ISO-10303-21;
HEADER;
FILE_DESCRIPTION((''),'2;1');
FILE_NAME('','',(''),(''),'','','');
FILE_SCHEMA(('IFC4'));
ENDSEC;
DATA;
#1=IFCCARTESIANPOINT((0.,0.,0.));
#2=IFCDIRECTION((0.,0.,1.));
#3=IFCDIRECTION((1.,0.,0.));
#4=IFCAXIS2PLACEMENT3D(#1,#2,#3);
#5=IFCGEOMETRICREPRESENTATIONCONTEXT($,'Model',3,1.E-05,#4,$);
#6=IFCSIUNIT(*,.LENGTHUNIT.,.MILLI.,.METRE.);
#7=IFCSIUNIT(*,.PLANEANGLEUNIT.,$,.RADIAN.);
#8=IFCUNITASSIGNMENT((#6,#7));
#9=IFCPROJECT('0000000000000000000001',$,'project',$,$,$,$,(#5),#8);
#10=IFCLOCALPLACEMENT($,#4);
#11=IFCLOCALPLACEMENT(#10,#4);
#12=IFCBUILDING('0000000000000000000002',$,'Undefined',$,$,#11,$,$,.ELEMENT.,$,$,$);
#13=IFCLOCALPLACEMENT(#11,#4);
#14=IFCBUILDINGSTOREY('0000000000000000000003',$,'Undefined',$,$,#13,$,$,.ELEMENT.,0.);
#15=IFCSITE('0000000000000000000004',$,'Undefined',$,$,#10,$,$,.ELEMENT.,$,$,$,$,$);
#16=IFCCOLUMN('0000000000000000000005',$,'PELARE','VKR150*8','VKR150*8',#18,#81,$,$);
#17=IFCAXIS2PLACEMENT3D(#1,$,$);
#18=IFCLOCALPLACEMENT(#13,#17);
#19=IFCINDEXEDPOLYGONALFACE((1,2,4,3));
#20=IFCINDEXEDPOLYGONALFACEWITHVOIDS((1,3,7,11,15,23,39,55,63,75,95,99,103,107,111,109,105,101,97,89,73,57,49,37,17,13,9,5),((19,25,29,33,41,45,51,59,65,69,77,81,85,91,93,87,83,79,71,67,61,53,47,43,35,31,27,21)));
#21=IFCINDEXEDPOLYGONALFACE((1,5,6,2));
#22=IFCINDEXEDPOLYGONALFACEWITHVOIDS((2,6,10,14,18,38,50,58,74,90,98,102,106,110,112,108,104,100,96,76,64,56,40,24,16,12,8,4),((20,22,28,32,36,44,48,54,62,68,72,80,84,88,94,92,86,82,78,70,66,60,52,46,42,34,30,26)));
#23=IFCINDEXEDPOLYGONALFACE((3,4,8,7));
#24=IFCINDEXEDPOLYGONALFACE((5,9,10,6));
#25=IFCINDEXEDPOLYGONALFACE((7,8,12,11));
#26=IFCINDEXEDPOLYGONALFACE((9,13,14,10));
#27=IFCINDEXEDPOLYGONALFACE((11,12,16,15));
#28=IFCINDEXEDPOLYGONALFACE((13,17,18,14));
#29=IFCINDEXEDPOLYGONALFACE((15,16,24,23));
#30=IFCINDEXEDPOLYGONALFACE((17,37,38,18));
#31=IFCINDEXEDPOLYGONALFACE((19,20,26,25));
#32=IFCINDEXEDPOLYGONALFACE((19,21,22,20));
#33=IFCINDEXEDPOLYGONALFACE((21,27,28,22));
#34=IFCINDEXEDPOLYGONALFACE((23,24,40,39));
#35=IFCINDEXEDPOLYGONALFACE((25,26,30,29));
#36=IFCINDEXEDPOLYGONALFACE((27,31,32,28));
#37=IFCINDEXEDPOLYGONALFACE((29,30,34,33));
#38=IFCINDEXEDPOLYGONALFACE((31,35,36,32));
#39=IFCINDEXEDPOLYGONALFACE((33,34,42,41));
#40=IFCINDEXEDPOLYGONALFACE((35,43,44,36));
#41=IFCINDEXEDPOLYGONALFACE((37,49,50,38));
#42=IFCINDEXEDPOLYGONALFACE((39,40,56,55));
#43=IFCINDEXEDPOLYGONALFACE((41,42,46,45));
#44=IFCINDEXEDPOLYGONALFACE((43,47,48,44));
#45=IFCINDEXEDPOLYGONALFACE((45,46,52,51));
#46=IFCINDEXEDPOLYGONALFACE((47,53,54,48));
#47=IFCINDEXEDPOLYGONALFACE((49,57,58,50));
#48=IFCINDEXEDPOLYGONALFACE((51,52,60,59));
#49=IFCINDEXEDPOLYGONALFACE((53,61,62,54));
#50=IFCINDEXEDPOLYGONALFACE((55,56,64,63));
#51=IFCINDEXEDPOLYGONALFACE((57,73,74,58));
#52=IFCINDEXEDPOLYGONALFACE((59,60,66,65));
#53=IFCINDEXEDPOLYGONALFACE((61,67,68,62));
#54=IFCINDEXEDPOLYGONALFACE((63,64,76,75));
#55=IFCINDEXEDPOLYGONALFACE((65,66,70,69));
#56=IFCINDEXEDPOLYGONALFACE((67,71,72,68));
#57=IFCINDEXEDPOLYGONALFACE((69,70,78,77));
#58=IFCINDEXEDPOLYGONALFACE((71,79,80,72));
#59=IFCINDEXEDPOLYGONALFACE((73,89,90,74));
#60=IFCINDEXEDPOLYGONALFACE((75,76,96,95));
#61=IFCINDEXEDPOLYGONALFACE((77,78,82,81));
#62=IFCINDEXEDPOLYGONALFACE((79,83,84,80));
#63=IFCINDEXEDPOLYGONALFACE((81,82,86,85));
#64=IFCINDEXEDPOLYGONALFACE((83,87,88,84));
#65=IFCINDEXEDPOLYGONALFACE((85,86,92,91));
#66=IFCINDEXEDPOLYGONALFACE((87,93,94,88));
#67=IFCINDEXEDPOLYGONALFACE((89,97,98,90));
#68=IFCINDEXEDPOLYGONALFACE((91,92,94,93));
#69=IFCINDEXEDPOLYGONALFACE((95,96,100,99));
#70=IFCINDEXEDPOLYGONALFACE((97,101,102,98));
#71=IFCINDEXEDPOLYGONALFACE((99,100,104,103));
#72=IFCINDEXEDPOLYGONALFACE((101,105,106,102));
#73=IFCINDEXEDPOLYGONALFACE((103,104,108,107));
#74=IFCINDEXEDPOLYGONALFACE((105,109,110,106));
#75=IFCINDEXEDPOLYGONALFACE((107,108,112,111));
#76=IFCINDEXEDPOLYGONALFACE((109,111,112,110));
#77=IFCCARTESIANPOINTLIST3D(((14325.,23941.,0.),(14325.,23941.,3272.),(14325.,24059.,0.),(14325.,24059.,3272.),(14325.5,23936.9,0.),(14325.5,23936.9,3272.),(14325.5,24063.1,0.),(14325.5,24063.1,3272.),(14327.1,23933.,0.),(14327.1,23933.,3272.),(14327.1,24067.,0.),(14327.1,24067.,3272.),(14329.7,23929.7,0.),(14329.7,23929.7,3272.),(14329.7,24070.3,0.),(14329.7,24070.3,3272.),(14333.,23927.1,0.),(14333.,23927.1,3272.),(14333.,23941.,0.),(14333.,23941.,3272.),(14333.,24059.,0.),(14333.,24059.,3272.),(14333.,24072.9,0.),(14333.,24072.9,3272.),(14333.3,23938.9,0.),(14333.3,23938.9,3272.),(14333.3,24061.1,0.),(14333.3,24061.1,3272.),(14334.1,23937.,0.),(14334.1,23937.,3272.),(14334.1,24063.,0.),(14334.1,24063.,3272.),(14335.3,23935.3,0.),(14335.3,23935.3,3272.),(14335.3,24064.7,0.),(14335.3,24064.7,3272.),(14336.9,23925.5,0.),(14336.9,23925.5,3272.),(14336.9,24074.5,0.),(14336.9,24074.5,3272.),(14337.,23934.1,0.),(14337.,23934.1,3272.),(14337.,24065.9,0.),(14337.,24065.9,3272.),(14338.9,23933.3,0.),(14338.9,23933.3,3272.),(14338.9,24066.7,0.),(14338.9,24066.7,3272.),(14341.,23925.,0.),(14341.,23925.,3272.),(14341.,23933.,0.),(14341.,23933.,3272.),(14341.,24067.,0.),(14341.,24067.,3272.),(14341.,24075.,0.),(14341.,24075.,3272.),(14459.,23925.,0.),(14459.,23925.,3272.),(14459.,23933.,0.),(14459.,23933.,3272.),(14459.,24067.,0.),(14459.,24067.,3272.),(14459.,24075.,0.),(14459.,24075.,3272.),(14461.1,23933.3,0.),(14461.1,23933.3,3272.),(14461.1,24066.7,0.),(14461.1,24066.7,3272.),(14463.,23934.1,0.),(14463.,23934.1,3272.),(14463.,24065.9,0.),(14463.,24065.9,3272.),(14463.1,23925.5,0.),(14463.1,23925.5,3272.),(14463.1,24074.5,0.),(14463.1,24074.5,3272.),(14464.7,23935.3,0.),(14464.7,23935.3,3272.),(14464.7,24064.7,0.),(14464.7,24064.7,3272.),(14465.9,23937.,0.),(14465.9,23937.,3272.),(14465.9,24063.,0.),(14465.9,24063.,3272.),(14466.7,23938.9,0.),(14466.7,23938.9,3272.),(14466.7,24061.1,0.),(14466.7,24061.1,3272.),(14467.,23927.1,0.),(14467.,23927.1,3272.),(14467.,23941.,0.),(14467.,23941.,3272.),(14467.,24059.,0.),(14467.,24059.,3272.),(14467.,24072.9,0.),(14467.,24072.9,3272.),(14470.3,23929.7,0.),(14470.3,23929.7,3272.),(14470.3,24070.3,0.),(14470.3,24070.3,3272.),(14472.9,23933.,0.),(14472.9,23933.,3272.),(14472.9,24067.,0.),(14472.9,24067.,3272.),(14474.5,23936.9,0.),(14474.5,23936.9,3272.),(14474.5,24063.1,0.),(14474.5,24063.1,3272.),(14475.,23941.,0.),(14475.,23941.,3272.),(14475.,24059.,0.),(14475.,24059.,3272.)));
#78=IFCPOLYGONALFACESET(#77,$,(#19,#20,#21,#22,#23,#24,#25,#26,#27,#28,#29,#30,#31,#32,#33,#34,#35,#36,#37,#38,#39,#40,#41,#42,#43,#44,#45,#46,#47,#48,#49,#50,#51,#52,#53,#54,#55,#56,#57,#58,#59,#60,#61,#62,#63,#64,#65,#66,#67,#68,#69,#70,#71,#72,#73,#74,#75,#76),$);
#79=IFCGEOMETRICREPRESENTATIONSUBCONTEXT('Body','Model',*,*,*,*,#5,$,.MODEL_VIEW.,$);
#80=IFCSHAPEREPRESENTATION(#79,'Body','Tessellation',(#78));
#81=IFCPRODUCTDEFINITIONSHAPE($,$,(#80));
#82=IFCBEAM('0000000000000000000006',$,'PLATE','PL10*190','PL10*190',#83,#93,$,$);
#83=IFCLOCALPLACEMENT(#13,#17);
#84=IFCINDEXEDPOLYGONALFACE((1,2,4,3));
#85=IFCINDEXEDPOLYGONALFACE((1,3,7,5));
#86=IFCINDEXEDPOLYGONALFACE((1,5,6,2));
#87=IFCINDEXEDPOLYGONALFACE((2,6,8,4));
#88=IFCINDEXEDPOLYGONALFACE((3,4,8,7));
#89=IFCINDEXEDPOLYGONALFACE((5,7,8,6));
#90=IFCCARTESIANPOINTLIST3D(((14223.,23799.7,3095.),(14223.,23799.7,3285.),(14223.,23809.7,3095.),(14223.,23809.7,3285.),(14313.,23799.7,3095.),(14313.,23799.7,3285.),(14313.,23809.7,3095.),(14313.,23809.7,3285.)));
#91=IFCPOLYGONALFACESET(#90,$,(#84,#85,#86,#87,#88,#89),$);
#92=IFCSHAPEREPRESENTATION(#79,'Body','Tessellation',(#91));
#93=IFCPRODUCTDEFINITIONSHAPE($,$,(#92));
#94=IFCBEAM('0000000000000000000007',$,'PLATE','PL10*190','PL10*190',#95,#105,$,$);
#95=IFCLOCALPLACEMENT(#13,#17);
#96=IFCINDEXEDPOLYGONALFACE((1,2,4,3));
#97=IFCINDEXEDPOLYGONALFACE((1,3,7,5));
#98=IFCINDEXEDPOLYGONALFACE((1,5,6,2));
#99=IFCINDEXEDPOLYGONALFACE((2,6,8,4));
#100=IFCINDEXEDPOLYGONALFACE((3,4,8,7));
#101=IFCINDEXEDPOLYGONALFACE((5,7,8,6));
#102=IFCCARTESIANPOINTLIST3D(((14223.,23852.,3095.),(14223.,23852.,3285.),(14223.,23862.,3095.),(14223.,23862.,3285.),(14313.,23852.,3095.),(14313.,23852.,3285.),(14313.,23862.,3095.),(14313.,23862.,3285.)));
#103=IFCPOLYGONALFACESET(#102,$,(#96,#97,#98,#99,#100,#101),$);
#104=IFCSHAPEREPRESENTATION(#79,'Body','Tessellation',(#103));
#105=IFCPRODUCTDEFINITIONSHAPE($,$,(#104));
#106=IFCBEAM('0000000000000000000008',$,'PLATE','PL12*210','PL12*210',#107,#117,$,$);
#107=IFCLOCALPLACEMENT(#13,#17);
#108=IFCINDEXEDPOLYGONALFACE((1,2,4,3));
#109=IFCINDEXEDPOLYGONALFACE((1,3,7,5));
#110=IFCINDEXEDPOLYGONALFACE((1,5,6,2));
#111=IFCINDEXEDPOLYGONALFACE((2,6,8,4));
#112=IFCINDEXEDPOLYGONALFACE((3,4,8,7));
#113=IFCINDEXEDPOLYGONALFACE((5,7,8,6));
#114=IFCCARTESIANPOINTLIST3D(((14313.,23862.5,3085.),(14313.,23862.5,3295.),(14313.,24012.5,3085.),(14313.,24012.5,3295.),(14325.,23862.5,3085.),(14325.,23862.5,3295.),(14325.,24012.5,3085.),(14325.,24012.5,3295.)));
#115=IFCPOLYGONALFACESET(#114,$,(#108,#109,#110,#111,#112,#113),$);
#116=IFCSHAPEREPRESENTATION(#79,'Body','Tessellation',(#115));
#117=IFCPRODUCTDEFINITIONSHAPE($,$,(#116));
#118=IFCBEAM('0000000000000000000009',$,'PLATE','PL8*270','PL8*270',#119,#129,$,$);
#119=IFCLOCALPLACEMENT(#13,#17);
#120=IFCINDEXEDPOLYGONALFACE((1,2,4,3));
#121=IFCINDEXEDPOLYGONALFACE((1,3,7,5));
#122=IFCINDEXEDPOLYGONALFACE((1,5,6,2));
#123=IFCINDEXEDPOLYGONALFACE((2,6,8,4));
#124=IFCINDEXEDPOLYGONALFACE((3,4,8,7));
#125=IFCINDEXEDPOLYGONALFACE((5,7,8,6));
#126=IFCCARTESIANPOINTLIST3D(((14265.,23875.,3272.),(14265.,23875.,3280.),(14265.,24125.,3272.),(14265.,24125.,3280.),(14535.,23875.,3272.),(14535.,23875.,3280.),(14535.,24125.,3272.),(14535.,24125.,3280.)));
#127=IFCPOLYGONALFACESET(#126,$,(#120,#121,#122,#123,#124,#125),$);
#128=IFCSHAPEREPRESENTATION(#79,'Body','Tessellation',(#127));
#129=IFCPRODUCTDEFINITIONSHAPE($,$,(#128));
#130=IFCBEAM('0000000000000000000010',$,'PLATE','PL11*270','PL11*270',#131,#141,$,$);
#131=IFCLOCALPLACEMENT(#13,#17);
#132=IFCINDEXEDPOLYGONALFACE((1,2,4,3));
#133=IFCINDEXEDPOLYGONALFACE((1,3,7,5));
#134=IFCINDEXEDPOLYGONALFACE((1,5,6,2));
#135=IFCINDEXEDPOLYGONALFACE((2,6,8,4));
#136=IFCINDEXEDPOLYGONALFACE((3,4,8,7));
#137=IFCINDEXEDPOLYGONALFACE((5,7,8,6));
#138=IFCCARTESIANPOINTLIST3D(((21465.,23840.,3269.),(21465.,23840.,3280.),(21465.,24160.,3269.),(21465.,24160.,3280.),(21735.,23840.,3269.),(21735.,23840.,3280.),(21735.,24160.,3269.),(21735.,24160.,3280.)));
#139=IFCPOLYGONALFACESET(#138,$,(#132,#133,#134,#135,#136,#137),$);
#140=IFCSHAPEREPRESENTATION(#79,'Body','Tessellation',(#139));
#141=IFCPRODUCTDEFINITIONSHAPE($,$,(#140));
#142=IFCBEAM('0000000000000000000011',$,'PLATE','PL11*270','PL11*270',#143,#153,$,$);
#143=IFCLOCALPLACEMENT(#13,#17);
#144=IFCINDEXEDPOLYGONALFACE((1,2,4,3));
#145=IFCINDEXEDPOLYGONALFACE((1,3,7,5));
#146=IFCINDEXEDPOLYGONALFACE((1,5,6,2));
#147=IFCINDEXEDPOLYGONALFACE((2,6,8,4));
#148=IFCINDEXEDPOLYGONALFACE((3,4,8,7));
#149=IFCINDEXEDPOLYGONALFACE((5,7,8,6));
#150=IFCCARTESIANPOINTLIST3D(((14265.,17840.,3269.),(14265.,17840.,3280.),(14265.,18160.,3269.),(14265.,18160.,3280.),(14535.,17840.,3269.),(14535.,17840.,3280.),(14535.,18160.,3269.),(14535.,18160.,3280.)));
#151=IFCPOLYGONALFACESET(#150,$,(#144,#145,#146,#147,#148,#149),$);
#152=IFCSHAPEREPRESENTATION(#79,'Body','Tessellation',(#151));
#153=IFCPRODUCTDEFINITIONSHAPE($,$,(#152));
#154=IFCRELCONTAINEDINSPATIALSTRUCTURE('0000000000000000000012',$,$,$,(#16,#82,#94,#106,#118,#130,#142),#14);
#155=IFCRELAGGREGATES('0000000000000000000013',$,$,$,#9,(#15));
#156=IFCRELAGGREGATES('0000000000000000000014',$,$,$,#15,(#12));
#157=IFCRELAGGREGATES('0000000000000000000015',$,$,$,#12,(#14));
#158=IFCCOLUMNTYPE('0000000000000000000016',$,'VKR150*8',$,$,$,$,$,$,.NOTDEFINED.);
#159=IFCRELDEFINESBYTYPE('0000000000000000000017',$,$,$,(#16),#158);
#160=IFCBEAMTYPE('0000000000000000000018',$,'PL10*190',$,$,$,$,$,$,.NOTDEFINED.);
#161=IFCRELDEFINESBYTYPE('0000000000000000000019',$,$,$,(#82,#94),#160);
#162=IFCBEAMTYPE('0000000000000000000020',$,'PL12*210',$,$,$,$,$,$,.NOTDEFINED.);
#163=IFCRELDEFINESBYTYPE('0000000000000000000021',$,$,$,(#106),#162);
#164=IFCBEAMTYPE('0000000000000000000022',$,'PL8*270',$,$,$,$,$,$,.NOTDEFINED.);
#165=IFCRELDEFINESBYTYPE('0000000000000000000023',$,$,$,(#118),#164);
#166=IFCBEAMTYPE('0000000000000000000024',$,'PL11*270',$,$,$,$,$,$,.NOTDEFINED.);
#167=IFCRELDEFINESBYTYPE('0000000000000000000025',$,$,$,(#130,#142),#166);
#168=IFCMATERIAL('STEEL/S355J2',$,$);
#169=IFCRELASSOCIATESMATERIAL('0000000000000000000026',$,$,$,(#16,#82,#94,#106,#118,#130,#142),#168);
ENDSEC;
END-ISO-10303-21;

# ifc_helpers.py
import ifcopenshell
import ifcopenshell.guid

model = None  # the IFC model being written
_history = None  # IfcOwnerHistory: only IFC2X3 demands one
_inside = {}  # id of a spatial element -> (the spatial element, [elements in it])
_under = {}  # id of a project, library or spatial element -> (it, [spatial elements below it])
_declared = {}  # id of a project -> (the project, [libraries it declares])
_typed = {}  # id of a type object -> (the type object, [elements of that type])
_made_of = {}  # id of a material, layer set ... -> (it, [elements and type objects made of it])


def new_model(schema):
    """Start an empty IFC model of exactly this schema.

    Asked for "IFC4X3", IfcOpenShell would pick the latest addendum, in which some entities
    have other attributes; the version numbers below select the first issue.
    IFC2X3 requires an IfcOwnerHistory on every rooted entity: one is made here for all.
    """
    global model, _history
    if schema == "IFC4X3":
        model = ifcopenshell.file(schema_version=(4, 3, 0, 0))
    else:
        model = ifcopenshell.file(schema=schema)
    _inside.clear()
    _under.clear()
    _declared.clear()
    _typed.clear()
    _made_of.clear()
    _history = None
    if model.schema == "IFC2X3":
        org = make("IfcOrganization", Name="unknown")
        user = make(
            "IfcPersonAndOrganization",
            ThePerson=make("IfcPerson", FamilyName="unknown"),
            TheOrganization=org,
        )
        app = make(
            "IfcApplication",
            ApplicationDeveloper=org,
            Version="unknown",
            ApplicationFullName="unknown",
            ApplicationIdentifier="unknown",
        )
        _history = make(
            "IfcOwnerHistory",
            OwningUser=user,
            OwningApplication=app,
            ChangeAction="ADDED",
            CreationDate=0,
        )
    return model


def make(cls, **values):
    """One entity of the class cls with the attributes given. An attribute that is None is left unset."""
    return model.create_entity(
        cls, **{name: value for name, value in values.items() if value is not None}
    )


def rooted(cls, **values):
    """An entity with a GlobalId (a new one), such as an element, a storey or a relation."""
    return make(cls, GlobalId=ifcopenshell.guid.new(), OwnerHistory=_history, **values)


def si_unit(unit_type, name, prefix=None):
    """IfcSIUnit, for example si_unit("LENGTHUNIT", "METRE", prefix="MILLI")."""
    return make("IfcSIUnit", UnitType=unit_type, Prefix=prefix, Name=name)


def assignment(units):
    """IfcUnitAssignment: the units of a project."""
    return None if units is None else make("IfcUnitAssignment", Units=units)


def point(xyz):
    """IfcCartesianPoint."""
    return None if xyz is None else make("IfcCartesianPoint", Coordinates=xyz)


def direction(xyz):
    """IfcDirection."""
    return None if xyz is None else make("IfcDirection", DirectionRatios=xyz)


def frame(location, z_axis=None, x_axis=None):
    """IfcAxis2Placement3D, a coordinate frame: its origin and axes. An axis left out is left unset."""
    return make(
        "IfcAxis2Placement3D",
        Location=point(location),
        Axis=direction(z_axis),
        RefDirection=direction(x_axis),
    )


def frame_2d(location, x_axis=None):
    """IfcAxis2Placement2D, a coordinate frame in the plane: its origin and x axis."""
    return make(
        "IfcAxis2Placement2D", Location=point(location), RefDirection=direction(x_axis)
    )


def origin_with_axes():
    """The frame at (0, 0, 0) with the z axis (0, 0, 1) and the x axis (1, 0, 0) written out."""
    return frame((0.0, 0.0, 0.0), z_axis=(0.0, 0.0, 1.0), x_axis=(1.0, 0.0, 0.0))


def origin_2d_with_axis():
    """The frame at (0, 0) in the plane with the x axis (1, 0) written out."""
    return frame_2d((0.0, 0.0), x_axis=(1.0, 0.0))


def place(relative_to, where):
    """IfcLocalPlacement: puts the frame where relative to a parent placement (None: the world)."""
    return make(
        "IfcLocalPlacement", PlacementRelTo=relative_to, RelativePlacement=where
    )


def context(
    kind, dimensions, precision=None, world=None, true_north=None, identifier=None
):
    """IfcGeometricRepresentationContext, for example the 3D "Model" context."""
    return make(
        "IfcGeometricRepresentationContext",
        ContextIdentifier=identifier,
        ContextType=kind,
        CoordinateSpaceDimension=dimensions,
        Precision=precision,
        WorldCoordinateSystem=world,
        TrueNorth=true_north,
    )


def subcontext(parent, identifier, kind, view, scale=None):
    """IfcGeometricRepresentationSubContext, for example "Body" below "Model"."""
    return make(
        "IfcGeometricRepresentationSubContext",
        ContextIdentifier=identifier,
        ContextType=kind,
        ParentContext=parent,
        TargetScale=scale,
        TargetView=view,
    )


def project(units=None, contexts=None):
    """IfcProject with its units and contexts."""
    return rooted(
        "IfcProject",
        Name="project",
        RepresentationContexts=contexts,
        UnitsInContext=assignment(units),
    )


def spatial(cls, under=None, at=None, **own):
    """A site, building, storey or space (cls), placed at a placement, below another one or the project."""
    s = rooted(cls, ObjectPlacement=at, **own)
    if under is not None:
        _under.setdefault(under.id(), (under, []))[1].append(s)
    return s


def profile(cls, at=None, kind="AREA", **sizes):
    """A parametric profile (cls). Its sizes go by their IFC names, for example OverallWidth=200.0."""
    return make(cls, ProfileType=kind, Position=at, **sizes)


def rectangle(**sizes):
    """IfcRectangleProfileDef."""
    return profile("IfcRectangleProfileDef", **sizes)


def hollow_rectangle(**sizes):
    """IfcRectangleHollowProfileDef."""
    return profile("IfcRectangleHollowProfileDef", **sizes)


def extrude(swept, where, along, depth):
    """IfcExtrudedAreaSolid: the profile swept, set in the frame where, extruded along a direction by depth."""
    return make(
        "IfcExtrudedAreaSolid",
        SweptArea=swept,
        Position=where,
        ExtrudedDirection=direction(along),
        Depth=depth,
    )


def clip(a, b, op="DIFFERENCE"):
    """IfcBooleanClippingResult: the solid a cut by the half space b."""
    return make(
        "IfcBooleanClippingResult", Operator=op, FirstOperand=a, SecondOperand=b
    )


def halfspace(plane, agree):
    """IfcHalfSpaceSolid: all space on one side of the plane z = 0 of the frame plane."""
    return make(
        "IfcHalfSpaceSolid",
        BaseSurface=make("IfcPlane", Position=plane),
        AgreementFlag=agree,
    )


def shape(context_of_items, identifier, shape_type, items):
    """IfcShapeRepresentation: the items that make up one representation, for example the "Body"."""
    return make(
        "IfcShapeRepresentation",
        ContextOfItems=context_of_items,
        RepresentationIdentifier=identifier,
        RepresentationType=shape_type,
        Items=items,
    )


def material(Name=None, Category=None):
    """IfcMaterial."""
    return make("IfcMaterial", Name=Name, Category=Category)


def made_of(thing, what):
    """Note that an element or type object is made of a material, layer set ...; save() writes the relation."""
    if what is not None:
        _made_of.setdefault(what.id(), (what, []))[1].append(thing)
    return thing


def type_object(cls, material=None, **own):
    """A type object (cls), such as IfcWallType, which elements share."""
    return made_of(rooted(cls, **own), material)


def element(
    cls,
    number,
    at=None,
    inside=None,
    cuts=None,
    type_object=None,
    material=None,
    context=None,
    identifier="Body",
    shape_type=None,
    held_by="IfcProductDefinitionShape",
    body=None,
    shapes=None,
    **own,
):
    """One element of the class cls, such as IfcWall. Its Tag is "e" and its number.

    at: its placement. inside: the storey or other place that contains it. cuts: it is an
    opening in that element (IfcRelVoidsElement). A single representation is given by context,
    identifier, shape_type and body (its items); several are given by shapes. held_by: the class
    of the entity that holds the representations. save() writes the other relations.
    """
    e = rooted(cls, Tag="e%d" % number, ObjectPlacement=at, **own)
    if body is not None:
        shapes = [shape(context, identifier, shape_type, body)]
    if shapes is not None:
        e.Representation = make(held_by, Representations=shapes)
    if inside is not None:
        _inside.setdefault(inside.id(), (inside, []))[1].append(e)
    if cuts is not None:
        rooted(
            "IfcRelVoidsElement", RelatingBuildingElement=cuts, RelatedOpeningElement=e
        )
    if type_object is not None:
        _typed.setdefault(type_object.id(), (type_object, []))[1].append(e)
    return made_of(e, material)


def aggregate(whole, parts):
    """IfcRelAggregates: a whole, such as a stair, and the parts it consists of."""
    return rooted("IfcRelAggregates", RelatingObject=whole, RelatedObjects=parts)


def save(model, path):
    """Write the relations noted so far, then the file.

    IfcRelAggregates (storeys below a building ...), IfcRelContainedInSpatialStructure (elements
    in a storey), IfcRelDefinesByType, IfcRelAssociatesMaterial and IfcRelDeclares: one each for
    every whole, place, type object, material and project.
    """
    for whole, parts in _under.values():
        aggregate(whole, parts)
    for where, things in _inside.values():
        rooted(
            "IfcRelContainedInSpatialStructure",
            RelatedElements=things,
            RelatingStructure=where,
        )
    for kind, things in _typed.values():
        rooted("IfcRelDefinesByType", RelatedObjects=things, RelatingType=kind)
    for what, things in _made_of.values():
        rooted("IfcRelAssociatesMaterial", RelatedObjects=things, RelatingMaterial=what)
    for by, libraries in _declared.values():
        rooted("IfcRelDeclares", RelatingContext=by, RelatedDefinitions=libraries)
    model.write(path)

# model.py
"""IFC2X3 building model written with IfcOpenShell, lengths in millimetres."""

from ifc_helpers import new_model, si_unit, frame, origin_with_axes, origin_2d_with_axis, place, context, subcontext, project, spatial, rectangle, hollow_rectangle, extrude, clip, halfspace, material, type_object, element, save


model = new_model("IFC2X3")

# Units and contexts
model_context = context("Model", 3, precision=1e-05, world=origin_with_axes())
body_context = subcontext(model_context, "Body", "Model", "MODEL_VIEW")
ifc_project = project(units=[si_unit("LENGTHUNIT", "METRE", prefix="MILLI"), si_unit("PLANEANGLEUNIT", "RADIAN")], contexts=[model_context])

# Site, building, storey
site_placement = place(None, origin_with_axes())
site = spatial("IfcSite", under=ifc_project, at=site_placement, Name="Undefined", CompositionType="ELEMENT")
building_placement = place(site_placement, origin_with_axes())
building = spatial("IfcBuilding", under=site, at=building_placement, Name="Undefined", CompositionType="ELEMENT")
storey_placement = place(building_placement, origin_with_axes())
storey = spatial("IfcBuildingStorey", under=building, at=storey_placement, Name="Undefined", CompositionType="ELEMENT", Elevation=0.0)

# Column
ifc_material_1 = material(Name="STEEL/S355J2")
column_type_1 = type_object("IfcColumnType", Name="VKR150*8", PredefinedType="NOTDEFINED")
column_1_placement = place(storey_placement, frame((14400.0, 24000.0, 0.0), z_axis=(0.0, 0.0, 1.0), x_axis=(0.0, 1.0, 0.0)))
element("IfcColumn", 1, at=column_1_placement, inside=storey, type_object=column_type_1, material=ifc_material_1, Name="PELARE", Description="VKR150*8", ObjectType="VKR150*8", context=body_context, shape_type="Clipping", body=[
    clip(extrude(hollow_rectangle(XDim=150.0, YDim=150.0, WallThickness=8.0, InnerFilletRadius=8.0, OuterFilletRadius=16.0, at=origin_2d_with_axis()), frame((0.0, 0.0, 3272.0), z_axis=(0.0, 0.0, -1.0), x_axis=(0.0, 1.0, 0.0)), (0.0, 0.0, 1.0), 3272.0), halfspace(frame((125.0, 0.0, 3272.0), z_axis=(0.0, 0.0, 1.0), x_axis=(0.0, -1.0, 0.0)), False)),
])

# Beams
beam_type_1 = type_object("IfcBeamType", Name="PL10*190", PredefinedType="NOTDEFINED")
for number, where, z_axis, x_axis, name in (
    (2, (14313.0, 23804.7, 3190.0), (0.0, 0.0, 1.0), (-1.0, 0.0, 0.0), "PLATE"),
    (3, (14313.0, 23857.0, 3190.0), (0.0, 0.0, 1.0), (-1.0, 0.0, 0.0), "PLATE"),
):
    element("IfcBeam", number, at=place(storey_placement, frame(where, z_axis=z_axis, x_axis=x_axis)), inside=storey, type_object=beam_type_1, material=ifc_material_1, Name=name, Description="PL10*190", ObjectType="PL10*190", context=body_context, shape_type="SweptSolid", body=[
        extrude(rectangle(XDim=10.0, YDim=190.0, at=origin_2d_with_axis()), frame((90.0, 0.0, 0.0), z_axis=(-1.0, 0.0, 0.0), x_axis=(0.0, -1.0, 0.0)), (0.0, 0.0, 1.0), 90.0),
    ])
beam_type_2 = type_object("IfcBeamType", Name="PL12*210", PredefinedType="NOTDEFINED")
beam_1_placement = place(storey_placement, frame((14319.0, 24012.5, 3190.0), z_axis=(0.0, 0.0, 1.0), x_axis=(0.0, -1.0, 0.0)))
element("IfcBeam", 4, at=beam_1_placement, inside=storey, type_object=beam_type_2, material=ifc_material_1, Name="PLATE", Description="PL12*210", ObjectType="PL12*210", context=body_context, shape_type="SweptSolid", body=[
    extrude(rectangle(XDim=12.0, YDim=210.0, at=origin_2d_with_axis()), frame((150.0, 0.0, 0.0), z_axis=(-1.0, 0.0, 0.0), x_axis=(0.0, -1.0, 0.0)), (0.0, 0.0, 1.0), 150.0),
])
beam_type_3 = type_object("IfcBeamType", Name="PL8*270", PredefinedType="NOTDEFINED")
beam_2_placement = place(storey_placement, frame((14400.0, 24125.0, 3276.0), z_axis=(1.0, 0.0, 0.0), x_axis=(0.0, -1.0, 0.0)))
element("IfcBeam", 5, at=beam_2_placement, inside=storey, type_object=beam_type_3, material=ifc_material_1, Name="PLATE", Description="PL8*270", ObjectType="PL8*270", context=body_context, shape_type="SweptSolid", body=[
    extrude(rectangle(XDim=8.0, YDim=270.0, at=origin_2d_with_axis()), frame((250.0, 0.0, 0.0), z_axis=(-1.0, 0.0, 0.0), x_axis=(0.0, -1.0, 0.0)), (0.0, 0.0, 1.0), 250.0),
])
beam_type_4 = type_object("IfcBeamType", Name="PL11*270", PredefinedType="NOTDEFINED")
for number, where, z_axis, x_axis, name in (
    (6, (21600.0, 24160.0, 3274.5), (1.0, 0.0, 0.0), (0.0, -1.0, 0.0), "PLATE"),
    (7, (14400.0, 18160.0, 3274.5), (1.0, 0.0, 0.0), (0.0, -1.0, 0.0), "PLATE"),
):
    element("IfcBeam", number, at=place(storey_placement, frame(where, z_axis=z_axis, x_axis=x_axis)), inside=storey, type_object=beam_type_4, material=ifc_material_1, Name=name, Description="PL11*270", ObjectType="PL11*270", context=body_context, shape_type="SweptSolid", body=[
        extrude(rectangle(XDim=11.0, YDim=270.0, at=origin_2d_with_axis()), frame((320.0, 0.0, 0.0), z_axis=(-1.0, 0.0, 0.0), x_axis=(0.0, -1.0, 0.0)), (0.0, 0.0, 1.0), 320.0),
    ])

save(model, "model.ifc")
